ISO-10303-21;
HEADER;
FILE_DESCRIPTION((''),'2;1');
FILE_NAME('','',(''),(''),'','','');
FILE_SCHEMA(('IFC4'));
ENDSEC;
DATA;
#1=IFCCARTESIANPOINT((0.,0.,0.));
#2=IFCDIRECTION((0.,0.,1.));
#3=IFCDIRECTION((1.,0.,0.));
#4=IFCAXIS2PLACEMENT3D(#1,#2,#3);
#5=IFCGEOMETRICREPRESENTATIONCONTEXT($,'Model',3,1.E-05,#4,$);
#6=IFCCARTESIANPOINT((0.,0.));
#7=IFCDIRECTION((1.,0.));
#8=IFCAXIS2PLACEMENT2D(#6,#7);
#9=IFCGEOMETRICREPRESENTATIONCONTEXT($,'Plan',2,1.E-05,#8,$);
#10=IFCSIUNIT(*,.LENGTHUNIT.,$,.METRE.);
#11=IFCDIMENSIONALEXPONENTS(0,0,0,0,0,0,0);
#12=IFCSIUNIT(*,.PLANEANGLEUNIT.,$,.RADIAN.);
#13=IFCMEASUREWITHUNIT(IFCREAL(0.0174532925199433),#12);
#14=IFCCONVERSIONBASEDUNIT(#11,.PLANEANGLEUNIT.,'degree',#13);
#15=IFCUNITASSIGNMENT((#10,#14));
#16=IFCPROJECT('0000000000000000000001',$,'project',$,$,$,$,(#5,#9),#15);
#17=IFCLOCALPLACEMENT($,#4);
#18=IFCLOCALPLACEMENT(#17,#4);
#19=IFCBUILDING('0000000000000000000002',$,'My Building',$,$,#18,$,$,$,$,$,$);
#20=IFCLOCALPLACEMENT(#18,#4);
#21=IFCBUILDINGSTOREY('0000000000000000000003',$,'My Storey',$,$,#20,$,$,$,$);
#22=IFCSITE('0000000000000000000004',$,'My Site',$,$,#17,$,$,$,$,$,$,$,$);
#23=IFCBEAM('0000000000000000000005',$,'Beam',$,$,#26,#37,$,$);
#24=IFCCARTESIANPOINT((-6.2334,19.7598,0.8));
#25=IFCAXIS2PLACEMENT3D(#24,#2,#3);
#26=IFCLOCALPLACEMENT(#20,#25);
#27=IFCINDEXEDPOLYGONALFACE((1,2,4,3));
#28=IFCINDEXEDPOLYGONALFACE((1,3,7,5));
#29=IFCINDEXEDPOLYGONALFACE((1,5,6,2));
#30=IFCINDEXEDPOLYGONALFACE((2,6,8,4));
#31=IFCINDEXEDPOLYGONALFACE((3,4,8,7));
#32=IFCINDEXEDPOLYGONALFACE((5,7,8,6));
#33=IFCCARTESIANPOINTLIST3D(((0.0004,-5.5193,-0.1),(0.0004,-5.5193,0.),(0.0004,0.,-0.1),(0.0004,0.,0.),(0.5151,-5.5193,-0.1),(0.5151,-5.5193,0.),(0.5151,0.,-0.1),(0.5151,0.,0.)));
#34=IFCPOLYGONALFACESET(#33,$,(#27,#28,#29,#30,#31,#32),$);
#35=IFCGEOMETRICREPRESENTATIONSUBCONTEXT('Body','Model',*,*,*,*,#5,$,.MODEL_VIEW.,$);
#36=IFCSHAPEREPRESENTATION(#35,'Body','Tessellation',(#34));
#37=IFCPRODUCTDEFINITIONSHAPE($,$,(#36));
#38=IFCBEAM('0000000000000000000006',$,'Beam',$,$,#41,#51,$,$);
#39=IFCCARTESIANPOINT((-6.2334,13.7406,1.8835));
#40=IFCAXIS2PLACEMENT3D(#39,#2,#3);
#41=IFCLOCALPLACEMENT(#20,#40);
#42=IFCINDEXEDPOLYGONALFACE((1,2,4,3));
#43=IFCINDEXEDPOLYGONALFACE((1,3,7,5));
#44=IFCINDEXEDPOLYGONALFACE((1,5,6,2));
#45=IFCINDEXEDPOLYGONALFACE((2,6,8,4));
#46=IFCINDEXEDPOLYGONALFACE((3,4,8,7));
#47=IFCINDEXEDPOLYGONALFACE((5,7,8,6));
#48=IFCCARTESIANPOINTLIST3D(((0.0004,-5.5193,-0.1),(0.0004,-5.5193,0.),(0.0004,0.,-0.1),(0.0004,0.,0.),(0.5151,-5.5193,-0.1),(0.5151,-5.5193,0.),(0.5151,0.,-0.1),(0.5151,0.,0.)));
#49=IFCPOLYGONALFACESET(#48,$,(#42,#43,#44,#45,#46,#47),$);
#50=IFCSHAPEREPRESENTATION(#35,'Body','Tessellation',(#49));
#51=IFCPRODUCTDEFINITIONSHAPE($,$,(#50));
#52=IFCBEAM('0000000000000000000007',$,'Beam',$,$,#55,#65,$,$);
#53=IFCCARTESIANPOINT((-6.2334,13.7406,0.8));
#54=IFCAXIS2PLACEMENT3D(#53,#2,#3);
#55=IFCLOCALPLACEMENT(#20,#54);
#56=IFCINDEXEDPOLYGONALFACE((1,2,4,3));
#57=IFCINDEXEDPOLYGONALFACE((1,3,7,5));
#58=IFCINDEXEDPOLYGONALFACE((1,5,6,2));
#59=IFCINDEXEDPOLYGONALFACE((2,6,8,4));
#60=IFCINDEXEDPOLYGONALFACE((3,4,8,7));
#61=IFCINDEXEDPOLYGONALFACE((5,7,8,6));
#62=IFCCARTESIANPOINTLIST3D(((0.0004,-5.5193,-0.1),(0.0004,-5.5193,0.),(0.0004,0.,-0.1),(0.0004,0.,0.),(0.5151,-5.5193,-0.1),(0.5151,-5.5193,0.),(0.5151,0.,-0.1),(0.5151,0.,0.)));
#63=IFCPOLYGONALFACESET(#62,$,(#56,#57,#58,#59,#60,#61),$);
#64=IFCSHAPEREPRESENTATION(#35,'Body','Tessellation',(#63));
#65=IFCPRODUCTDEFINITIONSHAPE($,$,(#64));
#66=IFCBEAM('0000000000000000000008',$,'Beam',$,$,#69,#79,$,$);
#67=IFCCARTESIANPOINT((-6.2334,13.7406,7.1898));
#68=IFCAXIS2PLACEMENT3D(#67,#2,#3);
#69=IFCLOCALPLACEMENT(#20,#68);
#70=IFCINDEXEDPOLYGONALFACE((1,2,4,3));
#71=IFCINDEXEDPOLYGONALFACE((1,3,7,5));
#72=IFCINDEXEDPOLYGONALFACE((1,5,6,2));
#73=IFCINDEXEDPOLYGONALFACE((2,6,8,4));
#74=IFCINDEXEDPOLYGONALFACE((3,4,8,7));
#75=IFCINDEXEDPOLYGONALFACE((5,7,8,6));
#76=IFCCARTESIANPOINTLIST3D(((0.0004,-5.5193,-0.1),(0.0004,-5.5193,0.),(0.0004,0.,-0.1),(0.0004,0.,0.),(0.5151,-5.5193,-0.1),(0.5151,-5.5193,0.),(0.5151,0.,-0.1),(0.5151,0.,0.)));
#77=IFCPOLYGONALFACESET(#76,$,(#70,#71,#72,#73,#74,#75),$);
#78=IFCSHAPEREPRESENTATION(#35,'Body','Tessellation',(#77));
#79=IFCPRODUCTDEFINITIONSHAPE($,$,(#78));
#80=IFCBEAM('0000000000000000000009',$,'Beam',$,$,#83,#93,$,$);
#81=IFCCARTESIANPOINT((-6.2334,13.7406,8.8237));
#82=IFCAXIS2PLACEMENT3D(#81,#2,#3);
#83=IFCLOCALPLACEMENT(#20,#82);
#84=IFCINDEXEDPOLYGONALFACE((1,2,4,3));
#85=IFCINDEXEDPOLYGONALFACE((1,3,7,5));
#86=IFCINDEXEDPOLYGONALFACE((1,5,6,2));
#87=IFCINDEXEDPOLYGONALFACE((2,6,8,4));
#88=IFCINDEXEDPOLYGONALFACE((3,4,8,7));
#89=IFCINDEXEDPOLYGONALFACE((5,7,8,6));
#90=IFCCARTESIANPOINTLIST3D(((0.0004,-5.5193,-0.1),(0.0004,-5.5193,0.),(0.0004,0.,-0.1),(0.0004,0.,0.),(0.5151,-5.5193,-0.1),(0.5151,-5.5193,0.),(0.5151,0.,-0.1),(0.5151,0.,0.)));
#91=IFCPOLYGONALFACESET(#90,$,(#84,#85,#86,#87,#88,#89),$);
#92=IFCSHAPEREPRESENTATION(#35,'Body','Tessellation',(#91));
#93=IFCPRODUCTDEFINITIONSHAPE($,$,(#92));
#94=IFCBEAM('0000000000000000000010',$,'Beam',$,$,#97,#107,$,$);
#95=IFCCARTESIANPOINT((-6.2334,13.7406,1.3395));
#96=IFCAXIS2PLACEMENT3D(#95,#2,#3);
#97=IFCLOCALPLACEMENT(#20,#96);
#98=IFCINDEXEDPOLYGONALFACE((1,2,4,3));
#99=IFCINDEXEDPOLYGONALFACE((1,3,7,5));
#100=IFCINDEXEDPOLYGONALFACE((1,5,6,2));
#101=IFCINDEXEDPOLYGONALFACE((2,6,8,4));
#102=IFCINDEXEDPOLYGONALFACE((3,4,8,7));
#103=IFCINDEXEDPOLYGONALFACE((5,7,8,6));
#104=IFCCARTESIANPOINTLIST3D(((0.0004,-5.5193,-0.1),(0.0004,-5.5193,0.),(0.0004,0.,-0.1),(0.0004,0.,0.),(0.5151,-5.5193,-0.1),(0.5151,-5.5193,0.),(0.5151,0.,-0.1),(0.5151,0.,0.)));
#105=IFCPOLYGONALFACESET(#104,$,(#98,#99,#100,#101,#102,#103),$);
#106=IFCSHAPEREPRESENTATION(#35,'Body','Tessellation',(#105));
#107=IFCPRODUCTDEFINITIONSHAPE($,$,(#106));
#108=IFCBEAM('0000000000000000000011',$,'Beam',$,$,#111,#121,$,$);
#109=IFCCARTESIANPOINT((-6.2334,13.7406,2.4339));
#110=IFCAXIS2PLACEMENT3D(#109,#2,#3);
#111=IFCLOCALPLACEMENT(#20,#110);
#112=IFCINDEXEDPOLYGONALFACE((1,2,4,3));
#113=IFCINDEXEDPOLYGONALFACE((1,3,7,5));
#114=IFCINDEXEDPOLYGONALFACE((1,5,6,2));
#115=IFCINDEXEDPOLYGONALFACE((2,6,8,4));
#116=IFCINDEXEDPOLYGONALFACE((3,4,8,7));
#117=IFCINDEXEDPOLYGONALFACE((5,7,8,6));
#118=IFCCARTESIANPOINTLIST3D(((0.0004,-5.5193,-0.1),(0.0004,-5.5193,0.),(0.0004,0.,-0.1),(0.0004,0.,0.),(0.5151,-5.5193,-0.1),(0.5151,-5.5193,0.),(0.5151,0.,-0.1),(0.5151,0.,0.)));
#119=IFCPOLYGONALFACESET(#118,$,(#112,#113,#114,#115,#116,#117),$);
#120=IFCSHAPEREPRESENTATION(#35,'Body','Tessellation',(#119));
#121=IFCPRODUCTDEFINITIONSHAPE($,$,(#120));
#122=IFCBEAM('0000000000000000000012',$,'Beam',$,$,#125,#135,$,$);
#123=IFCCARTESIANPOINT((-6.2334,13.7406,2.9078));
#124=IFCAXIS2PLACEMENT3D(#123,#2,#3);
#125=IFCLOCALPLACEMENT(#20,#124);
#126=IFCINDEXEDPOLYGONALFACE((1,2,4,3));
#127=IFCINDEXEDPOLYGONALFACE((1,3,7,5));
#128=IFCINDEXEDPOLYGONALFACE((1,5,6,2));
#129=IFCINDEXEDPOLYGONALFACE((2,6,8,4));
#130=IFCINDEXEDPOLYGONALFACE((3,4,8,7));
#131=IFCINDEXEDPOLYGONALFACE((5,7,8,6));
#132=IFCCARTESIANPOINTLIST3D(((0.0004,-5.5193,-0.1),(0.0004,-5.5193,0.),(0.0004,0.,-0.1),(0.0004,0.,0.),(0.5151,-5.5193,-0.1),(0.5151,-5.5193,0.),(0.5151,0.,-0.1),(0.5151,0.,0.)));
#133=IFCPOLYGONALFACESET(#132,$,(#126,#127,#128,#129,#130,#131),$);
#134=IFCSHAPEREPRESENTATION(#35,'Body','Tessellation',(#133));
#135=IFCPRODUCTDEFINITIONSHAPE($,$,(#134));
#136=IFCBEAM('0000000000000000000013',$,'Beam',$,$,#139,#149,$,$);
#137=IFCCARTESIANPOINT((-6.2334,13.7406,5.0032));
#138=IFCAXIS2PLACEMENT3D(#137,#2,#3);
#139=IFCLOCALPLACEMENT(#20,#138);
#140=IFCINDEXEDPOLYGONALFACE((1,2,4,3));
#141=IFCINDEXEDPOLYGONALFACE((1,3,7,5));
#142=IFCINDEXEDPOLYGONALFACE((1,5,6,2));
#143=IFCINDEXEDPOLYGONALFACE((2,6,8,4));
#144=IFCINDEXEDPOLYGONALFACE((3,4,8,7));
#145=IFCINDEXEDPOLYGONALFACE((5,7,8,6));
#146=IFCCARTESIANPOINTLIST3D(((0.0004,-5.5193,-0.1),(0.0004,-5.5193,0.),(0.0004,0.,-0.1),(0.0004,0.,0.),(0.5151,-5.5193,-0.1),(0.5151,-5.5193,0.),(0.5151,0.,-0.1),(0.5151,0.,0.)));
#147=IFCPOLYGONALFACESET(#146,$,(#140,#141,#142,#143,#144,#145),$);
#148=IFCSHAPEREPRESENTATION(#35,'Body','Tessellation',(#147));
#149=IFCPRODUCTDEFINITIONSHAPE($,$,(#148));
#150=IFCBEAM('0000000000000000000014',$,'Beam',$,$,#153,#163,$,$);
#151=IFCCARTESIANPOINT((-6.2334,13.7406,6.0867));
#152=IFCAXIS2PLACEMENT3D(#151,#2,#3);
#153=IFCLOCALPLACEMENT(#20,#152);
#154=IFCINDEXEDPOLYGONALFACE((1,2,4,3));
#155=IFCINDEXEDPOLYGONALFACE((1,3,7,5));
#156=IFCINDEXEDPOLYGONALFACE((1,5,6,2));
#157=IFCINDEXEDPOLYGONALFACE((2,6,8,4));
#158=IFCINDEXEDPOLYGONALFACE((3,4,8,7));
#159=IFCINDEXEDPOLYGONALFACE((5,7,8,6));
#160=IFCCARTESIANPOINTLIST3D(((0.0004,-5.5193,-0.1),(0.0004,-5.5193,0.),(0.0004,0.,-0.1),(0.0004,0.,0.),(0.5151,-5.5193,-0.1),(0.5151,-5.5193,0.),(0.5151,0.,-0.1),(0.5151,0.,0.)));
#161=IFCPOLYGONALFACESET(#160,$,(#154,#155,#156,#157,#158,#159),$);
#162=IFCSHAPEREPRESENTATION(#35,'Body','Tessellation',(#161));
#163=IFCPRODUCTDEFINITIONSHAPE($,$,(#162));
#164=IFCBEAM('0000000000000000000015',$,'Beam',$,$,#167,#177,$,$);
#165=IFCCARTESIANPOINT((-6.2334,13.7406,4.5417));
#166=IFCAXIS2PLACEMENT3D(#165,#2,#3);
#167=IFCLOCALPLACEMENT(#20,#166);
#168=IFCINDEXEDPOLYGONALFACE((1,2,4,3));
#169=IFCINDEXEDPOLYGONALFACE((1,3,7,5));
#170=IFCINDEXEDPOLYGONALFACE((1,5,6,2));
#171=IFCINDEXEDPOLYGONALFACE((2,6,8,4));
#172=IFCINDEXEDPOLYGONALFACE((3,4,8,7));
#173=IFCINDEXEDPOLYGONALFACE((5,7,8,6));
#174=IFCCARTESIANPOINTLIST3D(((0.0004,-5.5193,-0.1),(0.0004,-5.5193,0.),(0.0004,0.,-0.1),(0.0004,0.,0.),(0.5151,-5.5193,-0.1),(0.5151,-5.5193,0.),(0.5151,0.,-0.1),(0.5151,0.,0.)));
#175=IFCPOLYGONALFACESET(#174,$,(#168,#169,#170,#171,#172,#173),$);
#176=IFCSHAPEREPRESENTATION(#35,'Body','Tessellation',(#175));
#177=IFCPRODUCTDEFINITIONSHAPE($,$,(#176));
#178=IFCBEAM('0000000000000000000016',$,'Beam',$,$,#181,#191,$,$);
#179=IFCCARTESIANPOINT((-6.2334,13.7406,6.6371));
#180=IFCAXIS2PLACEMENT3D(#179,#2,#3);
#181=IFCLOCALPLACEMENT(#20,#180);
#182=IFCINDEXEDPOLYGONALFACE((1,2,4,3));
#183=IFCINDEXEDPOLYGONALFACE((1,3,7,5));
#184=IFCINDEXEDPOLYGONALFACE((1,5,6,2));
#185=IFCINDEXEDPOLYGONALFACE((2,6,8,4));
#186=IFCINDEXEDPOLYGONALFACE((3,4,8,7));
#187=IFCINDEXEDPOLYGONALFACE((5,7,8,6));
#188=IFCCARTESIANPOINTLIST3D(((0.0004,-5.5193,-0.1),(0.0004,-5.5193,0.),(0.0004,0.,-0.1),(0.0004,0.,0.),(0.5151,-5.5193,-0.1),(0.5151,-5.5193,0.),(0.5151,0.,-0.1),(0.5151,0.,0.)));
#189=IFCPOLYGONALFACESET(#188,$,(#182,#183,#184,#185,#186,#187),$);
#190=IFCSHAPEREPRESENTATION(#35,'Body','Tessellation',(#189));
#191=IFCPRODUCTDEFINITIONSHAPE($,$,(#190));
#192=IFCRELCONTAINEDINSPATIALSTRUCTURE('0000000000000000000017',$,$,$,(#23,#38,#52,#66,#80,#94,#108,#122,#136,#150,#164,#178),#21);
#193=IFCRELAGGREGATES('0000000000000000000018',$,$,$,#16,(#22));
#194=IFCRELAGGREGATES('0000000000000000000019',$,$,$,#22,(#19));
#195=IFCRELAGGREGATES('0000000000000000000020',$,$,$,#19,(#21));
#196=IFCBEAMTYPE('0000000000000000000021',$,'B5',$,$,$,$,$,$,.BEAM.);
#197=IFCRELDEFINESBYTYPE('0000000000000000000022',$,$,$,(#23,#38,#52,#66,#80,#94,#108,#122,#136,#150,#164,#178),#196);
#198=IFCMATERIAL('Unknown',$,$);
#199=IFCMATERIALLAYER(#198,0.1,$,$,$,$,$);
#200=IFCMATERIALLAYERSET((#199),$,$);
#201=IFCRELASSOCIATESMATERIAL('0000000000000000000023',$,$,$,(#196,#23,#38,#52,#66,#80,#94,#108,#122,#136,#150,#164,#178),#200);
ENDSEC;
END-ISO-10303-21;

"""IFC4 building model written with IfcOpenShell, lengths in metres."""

from ifc_helpers import new_model, entity, si_unit, converted_unit, frame, origin_with_axes, origin_2d_with_axis, place, context, subcontext, project, spatial, indexed_curve, outline, extrude, material, layer, layer_set, layer_usage, type_object, element, save


model = new_model("IFC4")

# Units and contexts
model_context = context("Model", 3, precision=1e-05, world=origin_with_axes())
plan_context = context("Plan", 2, precision=1e-05, world=origin_2d_with_axis())
body_context = subcontext(model_context, "Body", "Model", "MODEL_VIEW")
ifc_project = project(units=[si_unit("LENGTHUNIT", "METRE"), converted_unit("PLANEANGLEUNIT", "degree", entity("IfcReal", 0.0174532925199433), si_unit("PLANEANGLEUNIT", "RADIAN"), dimensions=[0, 0, 0, 0, 0, 0, 0])], contexts=[model_context, plan_context])

# Site, building, storey
site_placement = place(None, origin_with_axes())
site = spatial("IfcSite", under=ifc_project, at=site_placement, Name="My Site")
building_placement = place(site_placement, origin_with_axes())
building = spatial("IfcBuilding", under=site, at=building_placement, Name="My Building")
storey_placement = place(building_placement, origin_with_axes())
storey = spatial("IfcBuildingStorey", under=building, at=storey_placement, Name="My Storey")

# Shared definitions
ifc_material = material(Name="Unknown")

# Beams
ifc_layer_1 = layer(ifc_material, 0.1)
ifc_layer_set_1 = layer_set([ifc_layer_1])
ifc_layer_usage_1 = layer_usage(ifc_layer_set_1, "AXIS3", "POSITIVE", -0.1)
beam_type_1 = type_object("IfcBeamType", Name="B5", PredefinedType="BEAM", material=ifc_layer_set_1)
beam_1_placement = place(storey_placement, frame((-6.2334, 19.7598, 0.8), z_axis=(0.0, 0.0, 1.0), x_axis=(1.0, 0.0, 0.0)))
element("IfcBeam", 1, at=beam_1_placement, inside=storey, type_object=beam_type_1, material=ifc_layer_usage_1, Name="Beam", context=body_context, shape_type="SweptSolid", body=[
    extrude(outline(indexed_curve([(0.0, 0.0), (0.5151, 0.0), (0.5151, -5.5193), (0.0004, -5.5193), (0.0004, 0.0), (0.0, 0.0)])), frame((0.0, 0.0, -0.1), z_axis=(0.0, 0.0, 1.0), x_axis=(1.0, 0.0, 0.0)), (0.0, 0.0, 1.0), 0.1),
])
ifc_layer_usage_2 = layer_usage(ifc_layer_set_1, "AXIS3", "POSITIVE", -0.1)
beam_2_placement = place(storey_placement, frame((-6.2334, 13.7406, 1.8835), z_axis=(0.0, 0.0, 1.0), x_axis=(1.0, 0.0, 0.0)))
element("IfcBeam", 2, at=beam_2_placement, inside=storey, type_object=beam_type_1, material=ifc_layer_usage_2, Name="Beam", context=body_context, shape_type="SweptSolid", body=[
    extrude(outline(indexed_curve([(0.0, 0.0), (0.5151, 0.0), (0.5151, -5.5193), (0.0004, -5.5193), (0.0004, 0.0), (0.0, 0.0)])), frame((0.0, 0.0, -0.1), z_axis=(0.0, 0.0, 1.0), x_axis=(1.0, 0.0, 0.0)), (0.0, 0.0, 1.0), 0.1),
])
ifc_layer_usage_3 = layer_usage(ifc_layer_set_1, "AXIS3", "POSITIVE", -0.1)
beam_3_placement = place(storey_placement, frame((-6.2334, 13.7406, 0.8), z_axis=(0.0, 0.0, 1.0), x_axis=(1.0, 0.0, 0.0)))
element("IfcBeam", 3, at=beam_3_placement, inside=storey, type_object=beam_type_1, material=ifc_layer_usage_3, Name="Beam", context=body_context, shape_type="SweptSolid", body=[
    extrude(outline(indexed_curve([(0.0, 0.0), (0.5151, 0.0), (0.5151, -5.5193), (0.0004, -5.5193), (0.0004, 0.0), (0.0, 0.0)])), frame((0.0, 0.0, -0.1), z_axis=(0.0, 0.0, 1.0), x_axis=(1.0, 0.0, 0.0)), (0.0, 0.0, 1.0), 0.1),
])
ifc_layer_usage_4 = layer_usage(ifc_layer_set_1, "AXIS3", "POSITIVE", -0.1)
beam_4_placement = place(storey_placement, frame((-6.2334, 13.7406, 7.1898), z_axis=(0.0, 0.0, 1.0), x_axis=(1.0, 0.0, 0.0)))
element("IfcBeam", 4, at=beam_4_placement, inside=storey, type_object=beam_type_1, material=ifc_layer_usage_4, Name="Beam", context=body_context, shape_type="SweptSolid", body=[
    extrude(outline(indexed_curve([(0.0, 0.0), (0.5151, 0.0), (0.5151, -5.5193), (0.0004, -5.5193), (0.0004, 0.0), (0.0, 0.0)])), frame((0.0, 0.0, -0.1), z_axis=(0.0, 0.0, 1.0), x_axis=(1.0, 0.0, 0.0)), (0.0, 0.0, 1.0), 0.1),
])
ifc_layer_usage_5 = layer_usage(ifc_layer_set_1, "AXIS3", "POSITIVE", -0.1)
beam_5_placement = place(storey_placement, frame((-6.2334, 13.7406, 8.8237), z_axis=(0.0, 0.0, 1.0), x_axis=(1.0, 0.0, 0.0)))
element("IfcBeam", 5, at=beam_5_placement, inside=storey, type_object=beam_type_1, material=ifc_layer_usage_5, Name="Beam", context=body_context, shape_type="SweptSolid", body=[
    extrude(outline(indexed_curve([(0.0, 0.0), (0.5151, 0.0), (0.5151, -5.5193), (0.0004, -5.5193), (0.0004, 0.0), (0.0, 0.0)])), frame((0.0, 0.0, -0.1), z_axis=(0.0, 0.0, 1.0), x_axis=(1.0, 0.0, 0.0)), (0.0, 0.0, 1.0), 0.1),
])
ifc_layer_usage_6 = layer_usage(ifc_layer_set_1, "AXIS3", "POSITIVE", -0.1)
beam_6_placement = place(storey_placement, frame((-6.2334, 13.7406, 1.3395), z_axis=(0.0, 0.0, 1.0), x_axis=(1.0, 0.0, 0.0)))
element("IfcBeam", 6, at=beam_6_placement, inside=storey, type_object=beam_type_1, material=ifc_layer_usage_6, Name="Beam", context=body_context, shape_type="SweptSolid", body=[
    extrude(outline(indexed_curve([(0.0, 0.0), (0.5151, 0.0), (0.5151, -5.5193), (0.0004, -5.5193), (0.0004, 0.0), (0.0, 0.0)])), frame((0.0, 0.0, -0.1), z_axis=(0.0, 0.0, 1.0), x_axis=(1.0, 0.0, 0.0)), (0.0, 0.0, 1.0), 0.1),
])
ifc_layer_usage_7 = layer_usage(ifc_layer_set_1, "AXIS3", "POSITIVE", -0.1)
beam_7_placement = place(storey_placement, frame((-6.2334, 13.7406, 2.4339), z_axis=(0.0, 0.0, 1.0), x_axis=(1.0, 0.0, 0.0)))
element("IfcBeam", 7, at=beam_7_placement, inside=storey, type_object=beam_type_1, material=ifc_layer_usage_7, Name="Beam", context=body_context, shape_type="SweptSolid", body=[
    extrude(outline(indexed_curve([(0.0, 0.0), (0.5151, 0.0), (0.5151, -5.5193), (0.0004, -5.5193), (0.0004, 0.0), (0.0, 0.0)])), frame((0.0, 0.0, -0.1), z_axis=(0.0, 0.0, 1.0), x_axis=(1.0, 0.0, 0.0)), (0.0, 0.0, 1.0), 0.1),
])
ifc_layer_usage_8 = layer_usage(ifc_layer_set_1, "AXIS3", "POSITIVE", -0.1)
beam_8_placement = place(storey_placement, frame((-6.2334, 13.7406, 2.9078), z_axis=(0.0, 0.0, 1.0), x_axis=(1.0, 0.0, 0.0)))
element("IfcBeam", 8, at=beam_8_placement, inside=storey, type_object=beam_type_1, material=ifc_layer_usage_8, Name="Beam", context=body_context, shape_type="SweptSolid", body=[
    extrude(outline(indexed_curve([(0.0, 0.0), (0.5151, 0.0), (0.5151, -5.5193), (0.0004, -5.5193), (0.0004, 0.0), (0.0, 0.0)])), frame((0.0, 0.0, -0.1), z_axis=(0.0, 0.0, 1.0), x_axis=(1.0, 0.0, 0.0)), (0.0, 0.0, 1.0), 0.1),
])
ifc_layer_usage_9 = layer_usage(ifc_layer_set_1, "AXIS3", "POSITIVE", -0.1)
beam_9_placement = place(storey_placement, frame((-6.2334, 13.7406, 5.0032), z_axis=(0.0, 0.0, 1.0), x_axis=(1.0, 0.0, 0.0)))
element("IfcBeam", 9, at=beam_9_placement, inside=storey, type_object=beam_type_1, material=ifc_layer_usage_9, Name="Beam", context=body_context, shape_type="SweptSolid", body=[
    extrude(outline(indexed_curve([(0.0, 0.0), (0.5151, 0.0), (0.5151, -5.5193), (0.0004, -5.5193), (0.0004, 0.0), (0.0, 0.0)])), frame((0.0, 0.0, -0.1), z_axis=(0.0, 0.0, 1.0), x_axis=(1.0, 0.0, 0.0)), (0.0, 0.0, 1.0), 0.1),
])
ifc_layer_usage_10 = layer_usage(ifc_layer_set_1, "AXIS3", "POSITIVE", -0.1)
beam_10_placement = place(storey_placement, frame((-6.2334, 13.7406, 6.0867), z_axis=(0.0, 0.0, 1.0), x_axis=(1.0, 0.0, 0.0)))
element("IfcBeam", 10, at=beam_10_placement, inside=storey, type_object=beam_type_1, material=ifc_layer_usage_10, Name="Beam", context=body_context, shape_type="SweptSolid", body=[
    extrude(outline(indexed_curve([(0.0, 0.0), (0.5151, 0.0), (0.5151, -5.5193), (0.0004, -5.5193), (0.0004, 0.0), (0.0, 0.0)])), frame((0.0, 0.0, -0.1), z_axis=(0.0, 0.0, 1.0), x_axis=(1.0, 0.0, 0.0)), (0.0, 0.0, 1.0), 0.1),
])
ifc_layer_usage_11 = layer_usage(ifc_layer_set_1, "AXIS3", "POSITIVE", -0.1)
beam_11_placement = place(storey_placement, frame((-6.2334, 13.7406, 4.5417), z_axis=(0.0, 0.0, 1.0), x_axis=(1.0, 0.0, 0.0)))
element("IfcBeam", 11, at=beam_11_placement, inside=storey, type_object=beam_type_1, material=ifc_layer_usage_11, Name="Beam", context=body_context, shape_type="SweptSolid", body=[
    extrude(outline(indexed_curve([(0.0, 0.0), (0.5151, 0.0), (0.5151, -5.5193), (0.0004, -5.5193), (0.0004, 0.0), (0.0, 0.0)])), frame((0.0, 0.0, -0.1), z_axis=(0.0, 0.0, 1.0), x_axis=(1.0, 0.0, 0.0)), (0.0, 0.0, 1.0), 0.1),
])
ifc_layer_usage_12 = layer_usage(ifc_layer_set_1, "AXIS3", "POSITIVE", -0.1)
beam_12_placement = place(storey_placement, frame((-6.2334, 13.7406, 6.6371), z_axis=(0.0, 0.0, 1.0), x_axis=(1.0, 0.0, 0.0)))
element("IfcBeam", 12, at=beam_12_placement, inside=storey, type_object=beam_type_1, material=ifc_layer_usage_12, Name="Beam", context=body_context, shape_type="SweptSolid", body=[
    extrude(outline(indexed_curve([(0.0, 0.0), (0.5151, 0.0), (0.5151, -5.5193), (0.0004, -5.5193), (0.0004, 0.0), (0.0, 0.0)])), frame((0.0, 0.0, -0.1), z_axis=(0.0, 0.0, 1.0), x_axis=(1.0, 0.0, 0.0)), (0.0, 0.0, 1.0), 0.1),
])

save(model, "model.ifc")
